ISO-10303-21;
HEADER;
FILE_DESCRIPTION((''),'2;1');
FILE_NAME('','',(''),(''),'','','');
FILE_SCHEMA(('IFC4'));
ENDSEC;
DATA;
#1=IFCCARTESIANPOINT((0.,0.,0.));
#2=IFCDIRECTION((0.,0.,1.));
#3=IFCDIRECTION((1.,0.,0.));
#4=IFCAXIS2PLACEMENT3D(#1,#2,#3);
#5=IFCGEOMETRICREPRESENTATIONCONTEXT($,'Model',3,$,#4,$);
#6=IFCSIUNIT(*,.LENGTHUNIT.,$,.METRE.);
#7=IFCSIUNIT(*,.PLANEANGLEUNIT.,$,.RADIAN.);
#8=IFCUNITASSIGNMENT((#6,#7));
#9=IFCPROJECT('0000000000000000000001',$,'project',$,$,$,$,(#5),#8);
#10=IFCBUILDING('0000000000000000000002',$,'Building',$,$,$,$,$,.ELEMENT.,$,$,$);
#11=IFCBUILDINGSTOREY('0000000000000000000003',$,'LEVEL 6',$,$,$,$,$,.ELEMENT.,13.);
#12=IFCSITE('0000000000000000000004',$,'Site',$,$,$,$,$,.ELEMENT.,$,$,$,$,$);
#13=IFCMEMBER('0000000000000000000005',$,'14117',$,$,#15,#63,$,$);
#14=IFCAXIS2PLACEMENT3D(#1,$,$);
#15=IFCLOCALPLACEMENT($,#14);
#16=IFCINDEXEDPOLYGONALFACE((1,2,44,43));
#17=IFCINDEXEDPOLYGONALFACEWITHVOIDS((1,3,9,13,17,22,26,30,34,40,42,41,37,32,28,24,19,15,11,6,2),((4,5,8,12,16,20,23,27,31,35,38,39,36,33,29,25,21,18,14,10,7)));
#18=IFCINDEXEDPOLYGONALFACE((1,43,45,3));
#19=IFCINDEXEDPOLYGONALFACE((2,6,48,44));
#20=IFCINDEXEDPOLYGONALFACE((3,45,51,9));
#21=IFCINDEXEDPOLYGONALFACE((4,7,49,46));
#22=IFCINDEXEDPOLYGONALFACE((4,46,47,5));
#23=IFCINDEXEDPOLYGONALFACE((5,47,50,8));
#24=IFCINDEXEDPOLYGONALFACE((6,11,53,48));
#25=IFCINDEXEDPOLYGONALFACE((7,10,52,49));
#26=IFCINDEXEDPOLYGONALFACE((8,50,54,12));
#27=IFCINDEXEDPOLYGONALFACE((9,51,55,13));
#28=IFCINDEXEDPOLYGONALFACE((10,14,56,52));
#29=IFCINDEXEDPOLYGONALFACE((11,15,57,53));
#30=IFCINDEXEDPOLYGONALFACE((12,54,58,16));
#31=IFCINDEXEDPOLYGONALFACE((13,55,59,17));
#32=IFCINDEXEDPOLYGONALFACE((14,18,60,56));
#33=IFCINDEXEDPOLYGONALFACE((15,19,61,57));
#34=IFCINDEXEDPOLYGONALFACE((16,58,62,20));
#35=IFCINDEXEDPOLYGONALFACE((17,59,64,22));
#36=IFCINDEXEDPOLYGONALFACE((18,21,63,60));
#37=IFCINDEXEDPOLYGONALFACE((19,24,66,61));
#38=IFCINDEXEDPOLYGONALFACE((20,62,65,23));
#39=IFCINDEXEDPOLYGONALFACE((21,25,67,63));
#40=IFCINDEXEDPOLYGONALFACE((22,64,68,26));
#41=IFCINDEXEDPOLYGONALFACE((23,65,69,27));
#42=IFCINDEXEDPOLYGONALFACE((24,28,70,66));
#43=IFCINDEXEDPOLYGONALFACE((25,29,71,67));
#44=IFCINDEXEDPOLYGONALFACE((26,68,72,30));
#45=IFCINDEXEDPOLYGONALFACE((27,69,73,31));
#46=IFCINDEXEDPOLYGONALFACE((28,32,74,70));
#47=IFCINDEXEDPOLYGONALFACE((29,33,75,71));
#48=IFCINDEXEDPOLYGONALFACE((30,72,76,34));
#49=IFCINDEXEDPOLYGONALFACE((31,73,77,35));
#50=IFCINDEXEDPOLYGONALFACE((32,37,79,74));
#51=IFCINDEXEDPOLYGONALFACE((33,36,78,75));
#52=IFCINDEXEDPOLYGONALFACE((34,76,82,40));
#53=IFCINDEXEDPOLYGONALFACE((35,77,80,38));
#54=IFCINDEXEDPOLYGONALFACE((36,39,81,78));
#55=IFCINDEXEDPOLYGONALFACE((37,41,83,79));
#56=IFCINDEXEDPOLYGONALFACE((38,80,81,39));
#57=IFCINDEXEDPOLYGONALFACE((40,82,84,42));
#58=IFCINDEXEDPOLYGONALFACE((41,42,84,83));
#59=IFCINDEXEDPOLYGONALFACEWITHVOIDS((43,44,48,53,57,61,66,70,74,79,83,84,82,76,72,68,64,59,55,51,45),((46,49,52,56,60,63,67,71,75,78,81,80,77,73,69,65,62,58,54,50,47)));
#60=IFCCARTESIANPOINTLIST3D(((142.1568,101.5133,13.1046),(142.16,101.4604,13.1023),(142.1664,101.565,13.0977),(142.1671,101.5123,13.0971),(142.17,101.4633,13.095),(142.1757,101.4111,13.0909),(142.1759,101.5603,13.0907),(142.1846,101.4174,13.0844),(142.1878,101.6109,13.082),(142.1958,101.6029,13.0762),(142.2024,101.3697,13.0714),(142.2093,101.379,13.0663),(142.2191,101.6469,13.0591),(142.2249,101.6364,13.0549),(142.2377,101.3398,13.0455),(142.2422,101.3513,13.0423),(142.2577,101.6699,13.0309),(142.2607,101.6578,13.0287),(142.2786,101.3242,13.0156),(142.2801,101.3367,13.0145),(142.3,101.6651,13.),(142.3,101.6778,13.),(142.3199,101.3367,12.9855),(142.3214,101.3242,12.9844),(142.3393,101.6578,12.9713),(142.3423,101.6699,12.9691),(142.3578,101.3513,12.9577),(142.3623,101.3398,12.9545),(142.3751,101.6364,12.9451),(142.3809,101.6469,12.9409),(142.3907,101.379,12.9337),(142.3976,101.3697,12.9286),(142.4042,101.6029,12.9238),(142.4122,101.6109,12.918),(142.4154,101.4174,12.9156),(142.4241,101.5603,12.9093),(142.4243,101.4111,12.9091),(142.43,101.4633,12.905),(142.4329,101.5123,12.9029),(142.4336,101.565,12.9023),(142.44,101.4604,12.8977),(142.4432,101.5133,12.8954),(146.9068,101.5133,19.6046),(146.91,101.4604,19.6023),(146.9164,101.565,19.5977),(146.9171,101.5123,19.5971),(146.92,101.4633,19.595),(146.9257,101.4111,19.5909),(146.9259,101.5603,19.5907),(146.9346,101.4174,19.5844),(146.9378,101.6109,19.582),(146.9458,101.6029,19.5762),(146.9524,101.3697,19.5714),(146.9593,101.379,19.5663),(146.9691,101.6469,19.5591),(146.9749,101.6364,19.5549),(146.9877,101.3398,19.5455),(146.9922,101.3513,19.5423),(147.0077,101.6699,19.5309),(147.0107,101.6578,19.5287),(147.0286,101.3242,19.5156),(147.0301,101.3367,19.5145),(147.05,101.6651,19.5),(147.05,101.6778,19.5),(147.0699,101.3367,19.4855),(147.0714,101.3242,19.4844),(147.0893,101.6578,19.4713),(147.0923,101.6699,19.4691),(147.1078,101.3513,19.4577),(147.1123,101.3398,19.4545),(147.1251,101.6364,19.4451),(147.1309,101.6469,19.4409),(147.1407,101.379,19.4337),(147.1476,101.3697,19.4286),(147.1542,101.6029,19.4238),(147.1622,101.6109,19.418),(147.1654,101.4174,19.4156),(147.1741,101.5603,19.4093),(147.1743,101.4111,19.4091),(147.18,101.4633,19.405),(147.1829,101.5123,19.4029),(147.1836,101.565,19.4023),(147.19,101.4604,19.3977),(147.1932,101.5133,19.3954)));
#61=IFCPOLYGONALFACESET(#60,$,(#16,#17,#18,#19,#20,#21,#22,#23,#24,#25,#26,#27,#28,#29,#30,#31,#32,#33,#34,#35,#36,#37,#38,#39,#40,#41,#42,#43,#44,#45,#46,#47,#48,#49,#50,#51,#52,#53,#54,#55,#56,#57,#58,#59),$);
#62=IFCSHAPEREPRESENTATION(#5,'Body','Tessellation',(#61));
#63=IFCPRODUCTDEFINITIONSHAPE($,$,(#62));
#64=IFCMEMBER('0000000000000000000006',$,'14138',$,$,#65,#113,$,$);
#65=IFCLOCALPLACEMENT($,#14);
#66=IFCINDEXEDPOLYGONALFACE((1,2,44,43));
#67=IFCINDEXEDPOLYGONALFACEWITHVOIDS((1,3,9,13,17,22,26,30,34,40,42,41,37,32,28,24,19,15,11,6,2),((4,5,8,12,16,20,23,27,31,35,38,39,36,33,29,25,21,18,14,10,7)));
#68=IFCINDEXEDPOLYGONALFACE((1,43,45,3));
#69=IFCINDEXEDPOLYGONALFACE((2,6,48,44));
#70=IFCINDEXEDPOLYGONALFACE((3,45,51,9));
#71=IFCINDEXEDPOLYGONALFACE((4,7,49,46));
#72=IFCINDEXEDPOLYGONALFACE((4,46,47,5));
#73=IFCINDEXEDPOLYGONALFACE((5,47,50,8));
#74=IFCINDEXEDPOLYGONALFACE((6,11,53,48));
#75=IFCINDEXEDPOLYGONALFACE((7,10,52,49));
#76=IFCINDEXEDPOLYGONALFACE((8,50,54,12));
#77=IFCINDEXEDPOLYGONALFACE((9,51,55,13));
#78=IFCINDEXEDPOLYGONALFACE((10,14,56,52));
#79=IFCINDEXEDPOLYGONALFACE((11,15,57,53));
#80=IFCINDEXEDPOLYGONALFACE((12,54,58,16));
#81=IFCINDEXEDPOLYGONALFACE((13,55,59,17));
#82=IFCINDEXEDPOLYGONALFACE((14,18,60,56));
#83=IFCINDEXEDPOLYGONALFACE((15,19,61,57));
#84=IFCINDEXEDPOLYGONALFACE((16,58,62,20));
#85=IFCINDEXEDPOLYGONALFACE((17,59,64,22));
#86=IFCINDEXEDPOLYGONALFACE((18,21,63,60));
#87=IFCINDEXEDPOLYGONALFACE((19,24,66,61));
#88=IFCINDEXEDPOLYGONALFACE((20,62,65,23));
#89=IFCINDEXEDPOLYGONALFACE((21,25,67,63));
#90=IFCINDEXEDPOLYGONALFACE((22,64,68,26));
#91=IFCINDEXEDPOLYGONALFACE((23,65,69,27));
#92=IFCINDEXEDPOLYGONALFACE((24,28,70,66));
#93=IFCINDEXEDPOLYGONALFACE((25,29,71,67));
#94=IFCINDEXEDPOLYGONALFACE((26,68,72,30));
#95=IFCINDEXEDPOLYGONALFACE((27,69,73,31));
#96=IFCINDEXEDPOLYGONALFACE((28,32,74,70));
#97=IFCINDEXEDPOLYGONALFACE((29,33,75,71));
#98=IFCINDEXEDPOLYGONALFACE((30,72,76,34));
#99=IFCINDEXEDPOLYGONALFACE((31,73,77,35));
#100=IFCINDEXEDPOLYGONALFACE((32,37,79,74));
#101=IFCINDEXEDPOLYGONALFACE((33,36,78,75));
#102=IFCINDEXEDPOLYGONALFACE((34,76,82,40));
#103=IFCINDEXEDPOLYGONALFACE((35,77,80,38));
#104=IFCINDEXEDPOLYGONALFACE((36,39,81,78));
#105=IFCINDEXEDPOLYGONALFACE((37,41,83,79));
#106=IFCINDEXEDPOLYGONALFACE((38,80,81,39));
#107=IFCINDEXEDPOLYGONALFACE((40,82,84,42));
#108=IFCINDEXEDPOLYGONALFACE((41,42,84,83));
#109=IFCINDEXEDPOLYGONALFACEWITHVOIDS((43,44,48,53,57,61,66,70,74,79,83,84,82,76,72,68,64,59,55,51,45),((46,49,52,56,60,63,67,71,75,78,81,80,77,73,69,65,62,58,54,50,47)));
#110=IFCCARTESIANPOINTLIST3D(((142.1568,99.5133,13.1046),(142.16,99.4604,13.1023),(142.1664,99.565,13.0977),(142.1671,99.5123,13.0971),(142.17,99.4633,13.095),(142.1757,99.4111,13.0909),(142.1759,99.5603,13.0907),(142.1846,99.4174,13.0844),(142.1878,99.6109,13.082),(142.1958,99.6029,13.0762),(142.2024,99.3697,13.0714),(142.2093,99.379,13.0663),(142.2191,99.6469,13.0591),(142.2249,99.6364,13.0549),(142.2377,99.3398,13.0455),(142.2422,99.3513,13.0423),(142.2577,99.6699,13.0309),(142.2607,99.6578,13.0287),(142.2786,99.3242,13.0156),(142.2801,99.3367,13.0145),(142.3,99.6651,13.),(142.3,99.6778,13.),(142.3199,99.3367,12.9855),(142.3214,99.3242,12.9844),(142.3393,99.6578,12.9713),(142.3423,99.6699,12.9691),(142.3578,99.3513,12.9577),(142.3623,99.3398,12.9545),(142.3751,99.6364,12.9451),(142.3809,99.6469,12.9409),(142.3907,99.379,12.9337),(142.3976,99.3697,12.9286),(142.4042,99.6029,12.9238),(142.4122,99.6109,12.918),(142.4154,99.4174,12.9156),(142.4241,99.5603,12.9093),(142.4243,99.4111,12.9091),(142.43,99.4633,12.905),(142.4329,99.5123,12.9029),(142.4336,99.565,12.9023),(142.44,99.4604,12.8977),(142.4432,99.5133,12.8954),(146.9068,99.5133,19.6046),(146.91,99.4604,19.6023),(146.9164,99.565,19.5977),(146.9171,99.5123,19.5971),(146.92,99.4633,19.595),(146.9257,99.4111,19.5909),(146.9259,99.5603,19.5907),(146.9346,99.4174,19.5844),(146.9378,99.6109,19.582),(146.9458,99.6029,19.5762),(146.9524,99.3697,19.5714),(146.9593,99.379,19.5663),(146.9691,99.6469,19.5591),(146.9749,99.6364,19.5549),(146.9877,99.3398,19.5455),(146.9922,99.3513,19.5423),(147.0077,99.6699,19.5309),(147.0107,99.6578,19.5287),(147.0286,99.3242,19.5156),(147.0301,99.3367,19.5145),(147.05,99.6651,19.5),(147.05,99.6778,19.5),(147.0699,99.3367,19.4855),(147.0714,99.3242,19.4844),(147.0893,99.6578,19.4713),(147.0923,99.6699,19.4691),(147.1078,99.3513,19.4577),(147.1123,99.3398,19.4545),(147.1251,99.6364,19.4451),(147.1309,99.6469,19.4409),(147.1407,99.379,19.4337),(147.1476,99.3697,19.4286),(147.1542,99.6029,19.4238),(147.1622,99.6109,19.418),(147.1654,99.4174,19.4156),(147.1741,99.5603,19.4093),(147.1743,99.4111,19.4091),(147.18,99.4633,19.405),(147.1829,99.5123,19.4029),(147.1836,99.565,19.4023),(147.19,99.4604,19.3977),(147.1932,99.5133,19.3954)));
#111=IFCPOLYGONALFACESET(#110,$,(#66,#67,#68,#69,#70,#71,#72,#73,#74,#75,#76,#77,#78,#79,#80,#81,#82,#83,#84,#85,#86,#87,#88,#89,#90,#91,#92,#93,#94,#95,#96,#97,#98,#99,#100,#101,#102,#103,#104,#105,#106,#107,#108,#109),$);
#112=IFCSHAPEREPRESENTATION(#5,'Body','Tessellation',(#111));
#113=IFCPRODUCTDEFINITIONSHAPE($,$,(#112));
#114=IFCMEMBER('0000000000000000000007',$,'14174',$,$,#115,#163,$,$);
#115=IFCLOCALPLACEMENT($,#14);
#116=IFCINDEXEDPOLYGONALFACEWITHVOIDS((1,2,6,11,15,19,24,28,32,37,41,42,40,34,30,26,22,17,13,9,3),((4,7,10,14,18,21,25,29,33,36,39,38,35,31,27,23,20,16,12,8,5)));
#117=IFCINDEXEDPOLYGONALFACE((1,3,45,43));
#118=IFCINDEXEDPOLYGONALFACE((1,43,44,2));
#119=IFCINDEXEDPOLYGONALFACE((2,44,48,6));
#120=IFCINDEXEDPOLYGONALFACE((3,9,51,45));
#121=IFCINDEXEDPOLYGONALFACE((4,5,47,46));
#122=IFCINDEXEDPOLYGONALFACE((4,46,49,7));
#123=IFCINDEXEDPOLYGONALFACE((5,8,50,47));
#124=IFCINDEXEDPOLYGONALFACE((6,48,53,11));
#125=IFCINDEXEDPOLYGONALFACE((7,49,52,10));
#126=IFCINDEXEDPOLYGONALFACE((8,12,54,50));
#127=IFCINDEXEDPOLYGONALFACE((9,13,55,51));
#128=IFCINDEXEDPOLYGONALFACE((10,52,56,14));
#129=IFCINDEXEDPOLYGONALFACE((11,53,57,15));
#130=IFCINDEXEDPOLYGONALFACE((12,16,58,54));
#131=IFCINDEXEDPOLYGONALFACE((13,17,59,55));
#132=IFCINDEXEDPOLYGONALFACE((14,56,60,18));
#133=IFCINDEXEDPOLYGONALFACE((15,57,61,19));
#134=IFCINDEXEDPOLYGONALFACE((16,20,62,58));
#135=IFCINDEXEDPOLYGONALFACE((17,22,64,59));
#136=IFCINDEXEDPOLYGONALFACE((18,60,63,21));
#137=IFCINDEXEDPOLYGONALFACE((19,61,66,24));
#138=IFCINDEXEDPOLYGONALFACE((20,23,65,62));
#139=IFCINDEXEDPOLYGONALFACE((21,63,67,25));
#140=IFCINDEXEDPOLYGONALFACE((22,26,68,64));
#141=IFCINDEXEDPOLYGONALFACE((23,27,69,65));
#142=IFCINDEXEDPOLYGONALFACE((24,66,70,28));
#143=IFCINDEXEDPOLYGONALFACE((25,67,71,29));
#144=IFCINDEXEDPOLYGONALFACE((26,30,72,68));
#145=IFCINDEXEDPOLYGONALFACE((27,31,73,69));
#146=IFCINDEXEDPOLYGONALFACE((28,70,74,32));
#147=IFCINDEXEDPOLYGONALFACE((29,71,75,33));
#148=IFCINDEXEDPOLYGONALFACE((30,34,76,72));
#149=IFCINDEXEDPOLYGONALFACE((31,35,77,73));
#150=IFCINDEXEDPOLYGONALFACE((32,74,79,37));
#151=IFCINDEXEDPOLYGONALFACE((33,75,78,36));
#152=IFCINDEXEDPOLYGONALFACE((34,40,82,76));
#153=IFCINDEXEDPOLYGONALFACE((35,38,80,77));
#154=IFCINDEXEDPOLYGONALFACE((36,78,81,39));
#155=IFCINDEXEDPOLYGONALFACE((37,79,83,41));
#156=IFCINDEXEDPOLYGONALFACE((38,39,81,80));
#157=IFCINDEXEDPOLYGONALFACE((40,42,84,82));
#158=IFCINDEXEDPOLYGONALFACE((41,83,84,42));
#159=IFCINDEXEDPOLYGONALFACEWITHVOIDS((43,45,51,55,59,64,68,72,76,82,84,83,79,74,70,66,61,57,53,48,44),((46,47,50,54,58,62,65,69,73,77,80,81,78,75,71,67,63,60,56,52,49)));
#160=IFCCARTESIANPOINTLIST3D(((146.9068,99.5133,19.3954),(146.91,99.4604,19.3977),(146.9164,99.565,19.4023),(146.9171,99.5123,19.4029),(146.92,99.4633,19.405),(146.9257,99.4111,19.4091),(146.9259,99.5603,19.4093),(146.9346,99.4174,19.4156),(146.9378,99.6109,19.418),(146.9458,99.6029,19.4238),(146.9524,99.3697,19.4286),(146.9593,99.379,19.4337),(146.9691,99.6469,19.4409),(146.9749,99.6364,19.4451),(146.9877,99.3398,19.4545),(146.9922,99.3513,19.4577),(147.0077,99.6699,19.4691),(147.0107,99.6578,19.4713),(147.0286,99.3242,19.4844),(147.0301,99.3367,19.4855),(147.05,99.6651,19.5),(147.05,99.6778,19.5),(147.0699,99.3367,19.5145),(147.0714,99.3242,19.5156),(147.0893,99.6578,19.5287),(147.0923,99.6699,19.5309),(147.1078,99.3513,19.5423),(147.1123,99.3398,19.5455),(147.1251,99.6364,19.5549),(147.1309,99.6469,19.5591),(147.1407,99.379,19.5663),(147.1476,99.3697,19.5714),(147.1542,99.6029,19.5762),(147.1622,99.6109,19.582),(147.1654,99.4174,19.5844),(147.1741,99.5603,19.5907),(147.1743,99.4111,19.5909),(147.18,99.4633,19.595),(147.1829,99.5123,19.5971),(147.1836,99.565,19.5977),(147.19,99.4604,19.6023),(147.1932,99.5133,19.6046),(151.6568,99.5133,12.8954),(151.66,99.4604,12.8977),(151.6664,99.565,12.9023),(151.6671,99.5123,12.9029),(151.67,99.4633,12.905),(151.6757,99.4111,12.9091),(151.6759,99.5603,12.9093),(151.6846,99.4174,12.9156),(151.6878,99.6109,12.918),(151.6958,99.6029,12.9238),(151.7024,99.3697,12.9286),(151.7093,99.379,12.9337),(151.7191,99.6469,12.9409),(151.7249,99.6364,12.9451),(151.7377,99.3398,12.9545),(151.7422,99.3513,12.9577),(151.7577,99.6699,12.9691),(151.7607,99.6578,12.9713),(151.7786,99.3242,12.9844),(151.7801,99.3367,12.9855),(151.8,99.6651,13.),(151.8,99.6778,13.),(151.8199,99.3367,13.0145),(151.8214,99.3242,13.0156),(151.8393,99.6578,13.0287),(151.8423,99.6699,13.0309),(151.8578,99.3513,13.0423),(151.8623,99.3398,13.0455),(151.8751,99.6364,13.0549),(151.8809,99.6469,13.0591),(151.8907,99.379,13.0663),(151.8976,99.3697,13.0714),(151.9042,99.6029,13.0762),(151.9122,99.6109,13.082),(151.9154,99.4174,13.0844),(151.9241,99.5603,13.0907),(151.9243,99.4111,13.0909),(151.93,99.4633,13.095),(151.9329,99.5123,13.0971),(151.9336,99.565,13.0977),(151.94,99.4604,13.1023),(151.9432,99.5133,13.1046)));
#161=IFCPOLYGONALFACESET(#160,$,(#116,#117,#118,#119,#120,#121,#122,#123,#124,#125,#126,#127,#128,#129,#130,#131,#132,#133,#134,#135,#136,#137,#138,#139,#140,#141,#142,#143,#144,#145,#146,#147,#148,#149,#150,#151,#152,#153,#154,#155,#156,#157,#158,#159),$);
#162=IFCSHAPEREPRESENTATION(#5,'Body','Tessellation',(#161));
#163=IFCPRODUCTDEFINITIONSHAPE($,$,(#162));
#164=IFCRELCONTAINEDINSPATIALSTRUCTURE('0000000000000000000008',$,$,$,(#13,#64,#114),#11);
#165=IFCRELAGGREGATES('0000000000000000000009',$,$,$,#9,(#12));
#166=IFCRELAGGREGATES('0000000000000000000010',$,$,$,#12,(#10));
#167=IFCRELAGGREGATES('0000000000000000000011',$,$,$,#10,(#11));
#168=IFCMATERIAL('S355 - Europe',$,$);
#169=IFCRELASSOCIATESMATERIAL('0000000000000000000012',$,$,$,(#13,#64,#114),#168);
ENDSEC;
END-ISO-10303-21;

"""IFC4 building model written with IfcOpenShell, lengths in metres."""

from ifc_helpers import new_model, si_unit, frame, origin_with_axes, origin_2d_with_axis, place, context, project, spatial, hollow_circle, extrude, material, material_profile, profile_set, profile_usage, element, save


model = new_model("IFC4")

# Units and contexts
model_context = context("Model", 3, world=origin_with_axes())
ifc_project = project(units=[si_unit("LENGTHUNIT", "METRE"), si_unit("PLANEANGLEUNIT", "RADIAN")], contexts=[model_context])

# Site, building, storey
site = spatial("IfcSite", under=ifc_project, Name="Site", CompositionType="ELEMENT")
building = spatial("IfcBuilding", under=site, Name="Building", CompositionType="ELEMENT")
storey = spatial("IfcBuildingStorey", under=building, Name="LEVEL 6", CompositionType="ELEMENT", Elevation=13.0)

# Shared definitions
ifc_material = material(Name="S355 - Europe")

# Members
ifc_material_profile_1 = material_profile(ifc_material, hollow_circle(Radius=0.1778, WallThickness=0.0127, at=origin_2d_with_axis()))
ifc_profile_set_1 = profile_set([ifc_material_profile_1])
ifc_profile_usage_1 = profile_usage(ifc_profile_set_1, cardinal=10)
member_1_placement = place(None, frame((142.3, 101.5, 13.0), z_axis=(0.590017, 0.0, 0.807391), x_axis=(0.0, 1.0, 0.0)))
element("IfcMember", 1, at=member_1_placement, inside=storey, material=ifc_profile_usage_1, Name="14117", context=model_context, shape_type="SweptSolid", body=[
    extrude(hollow_circle(Radius=0.1778, WallThickness=0.0127, at=origin_2d_with_axis()), origin_with_axes(), (0.0, 0.0, 1.0), 8.0506),
])
ifc_material_profile_2 = material_profile(ifc_material, hollow_circle(Radius=0.1778, WallThickness=0.0127, at=origin_2d_with_axis()))
ifc_profile_set_2 = profile_set([ifc_material_profile_2])
ifc_profile_usage_2 = profile_usage(ifc_profile_set_2, cardinal=10)
member_2_placement = place(None, frame((142.3, 99.5, 13.0), z_axis=(0.590017, 0.0, 0.807391), x_axis=(0.0, 1.0, 0.0)))
element("IfcMember", 2, at=member_2_placement, inside=storey, material=ifc_profile_usage_2, Name="14138", context=model_context, shape_type="SweptSolid", body=[
    extrude(hollow_circle(Radius=0.1778, WallThickness=0.0127, at=origin_2d_with_axis()), origin_with_axes(), (0.0, 0.0, 1.0), 8.0506),
])
ifc_material_profile_3 = material_profile(ifc_material, hollow_circle(Radius=0.1778, WallThickness=0.0127, at=origin_2d_with_axis()))
ifc_profile_set_3 = profile_set([ifc_material_profile_3])
ifc_profile_usage_3 = profile_usage(ifc_profile_set_3, cardinal=10)
member_3_placement = place(None, frame((147.05, 99.5, 19.5), z_axis=(0.590017, 0.0, -0.807391), x_axis=(0.0, 1.0, 0.0)))
element("IfcMember", 3, at=member_3_placement, inside=storey, material=ifc_profile_usage_3, Name="14174", context=model_context, shape_type="SweptSolid", body=[
    extrude(hollow_circle(Radius=0.1778, WallThickness=0.0127, at=origin_2d_with_axis()), origin_with_axes(), (0.0, 0.0, 1.0), 8.0506),
])

save(model, "model.ifc")
